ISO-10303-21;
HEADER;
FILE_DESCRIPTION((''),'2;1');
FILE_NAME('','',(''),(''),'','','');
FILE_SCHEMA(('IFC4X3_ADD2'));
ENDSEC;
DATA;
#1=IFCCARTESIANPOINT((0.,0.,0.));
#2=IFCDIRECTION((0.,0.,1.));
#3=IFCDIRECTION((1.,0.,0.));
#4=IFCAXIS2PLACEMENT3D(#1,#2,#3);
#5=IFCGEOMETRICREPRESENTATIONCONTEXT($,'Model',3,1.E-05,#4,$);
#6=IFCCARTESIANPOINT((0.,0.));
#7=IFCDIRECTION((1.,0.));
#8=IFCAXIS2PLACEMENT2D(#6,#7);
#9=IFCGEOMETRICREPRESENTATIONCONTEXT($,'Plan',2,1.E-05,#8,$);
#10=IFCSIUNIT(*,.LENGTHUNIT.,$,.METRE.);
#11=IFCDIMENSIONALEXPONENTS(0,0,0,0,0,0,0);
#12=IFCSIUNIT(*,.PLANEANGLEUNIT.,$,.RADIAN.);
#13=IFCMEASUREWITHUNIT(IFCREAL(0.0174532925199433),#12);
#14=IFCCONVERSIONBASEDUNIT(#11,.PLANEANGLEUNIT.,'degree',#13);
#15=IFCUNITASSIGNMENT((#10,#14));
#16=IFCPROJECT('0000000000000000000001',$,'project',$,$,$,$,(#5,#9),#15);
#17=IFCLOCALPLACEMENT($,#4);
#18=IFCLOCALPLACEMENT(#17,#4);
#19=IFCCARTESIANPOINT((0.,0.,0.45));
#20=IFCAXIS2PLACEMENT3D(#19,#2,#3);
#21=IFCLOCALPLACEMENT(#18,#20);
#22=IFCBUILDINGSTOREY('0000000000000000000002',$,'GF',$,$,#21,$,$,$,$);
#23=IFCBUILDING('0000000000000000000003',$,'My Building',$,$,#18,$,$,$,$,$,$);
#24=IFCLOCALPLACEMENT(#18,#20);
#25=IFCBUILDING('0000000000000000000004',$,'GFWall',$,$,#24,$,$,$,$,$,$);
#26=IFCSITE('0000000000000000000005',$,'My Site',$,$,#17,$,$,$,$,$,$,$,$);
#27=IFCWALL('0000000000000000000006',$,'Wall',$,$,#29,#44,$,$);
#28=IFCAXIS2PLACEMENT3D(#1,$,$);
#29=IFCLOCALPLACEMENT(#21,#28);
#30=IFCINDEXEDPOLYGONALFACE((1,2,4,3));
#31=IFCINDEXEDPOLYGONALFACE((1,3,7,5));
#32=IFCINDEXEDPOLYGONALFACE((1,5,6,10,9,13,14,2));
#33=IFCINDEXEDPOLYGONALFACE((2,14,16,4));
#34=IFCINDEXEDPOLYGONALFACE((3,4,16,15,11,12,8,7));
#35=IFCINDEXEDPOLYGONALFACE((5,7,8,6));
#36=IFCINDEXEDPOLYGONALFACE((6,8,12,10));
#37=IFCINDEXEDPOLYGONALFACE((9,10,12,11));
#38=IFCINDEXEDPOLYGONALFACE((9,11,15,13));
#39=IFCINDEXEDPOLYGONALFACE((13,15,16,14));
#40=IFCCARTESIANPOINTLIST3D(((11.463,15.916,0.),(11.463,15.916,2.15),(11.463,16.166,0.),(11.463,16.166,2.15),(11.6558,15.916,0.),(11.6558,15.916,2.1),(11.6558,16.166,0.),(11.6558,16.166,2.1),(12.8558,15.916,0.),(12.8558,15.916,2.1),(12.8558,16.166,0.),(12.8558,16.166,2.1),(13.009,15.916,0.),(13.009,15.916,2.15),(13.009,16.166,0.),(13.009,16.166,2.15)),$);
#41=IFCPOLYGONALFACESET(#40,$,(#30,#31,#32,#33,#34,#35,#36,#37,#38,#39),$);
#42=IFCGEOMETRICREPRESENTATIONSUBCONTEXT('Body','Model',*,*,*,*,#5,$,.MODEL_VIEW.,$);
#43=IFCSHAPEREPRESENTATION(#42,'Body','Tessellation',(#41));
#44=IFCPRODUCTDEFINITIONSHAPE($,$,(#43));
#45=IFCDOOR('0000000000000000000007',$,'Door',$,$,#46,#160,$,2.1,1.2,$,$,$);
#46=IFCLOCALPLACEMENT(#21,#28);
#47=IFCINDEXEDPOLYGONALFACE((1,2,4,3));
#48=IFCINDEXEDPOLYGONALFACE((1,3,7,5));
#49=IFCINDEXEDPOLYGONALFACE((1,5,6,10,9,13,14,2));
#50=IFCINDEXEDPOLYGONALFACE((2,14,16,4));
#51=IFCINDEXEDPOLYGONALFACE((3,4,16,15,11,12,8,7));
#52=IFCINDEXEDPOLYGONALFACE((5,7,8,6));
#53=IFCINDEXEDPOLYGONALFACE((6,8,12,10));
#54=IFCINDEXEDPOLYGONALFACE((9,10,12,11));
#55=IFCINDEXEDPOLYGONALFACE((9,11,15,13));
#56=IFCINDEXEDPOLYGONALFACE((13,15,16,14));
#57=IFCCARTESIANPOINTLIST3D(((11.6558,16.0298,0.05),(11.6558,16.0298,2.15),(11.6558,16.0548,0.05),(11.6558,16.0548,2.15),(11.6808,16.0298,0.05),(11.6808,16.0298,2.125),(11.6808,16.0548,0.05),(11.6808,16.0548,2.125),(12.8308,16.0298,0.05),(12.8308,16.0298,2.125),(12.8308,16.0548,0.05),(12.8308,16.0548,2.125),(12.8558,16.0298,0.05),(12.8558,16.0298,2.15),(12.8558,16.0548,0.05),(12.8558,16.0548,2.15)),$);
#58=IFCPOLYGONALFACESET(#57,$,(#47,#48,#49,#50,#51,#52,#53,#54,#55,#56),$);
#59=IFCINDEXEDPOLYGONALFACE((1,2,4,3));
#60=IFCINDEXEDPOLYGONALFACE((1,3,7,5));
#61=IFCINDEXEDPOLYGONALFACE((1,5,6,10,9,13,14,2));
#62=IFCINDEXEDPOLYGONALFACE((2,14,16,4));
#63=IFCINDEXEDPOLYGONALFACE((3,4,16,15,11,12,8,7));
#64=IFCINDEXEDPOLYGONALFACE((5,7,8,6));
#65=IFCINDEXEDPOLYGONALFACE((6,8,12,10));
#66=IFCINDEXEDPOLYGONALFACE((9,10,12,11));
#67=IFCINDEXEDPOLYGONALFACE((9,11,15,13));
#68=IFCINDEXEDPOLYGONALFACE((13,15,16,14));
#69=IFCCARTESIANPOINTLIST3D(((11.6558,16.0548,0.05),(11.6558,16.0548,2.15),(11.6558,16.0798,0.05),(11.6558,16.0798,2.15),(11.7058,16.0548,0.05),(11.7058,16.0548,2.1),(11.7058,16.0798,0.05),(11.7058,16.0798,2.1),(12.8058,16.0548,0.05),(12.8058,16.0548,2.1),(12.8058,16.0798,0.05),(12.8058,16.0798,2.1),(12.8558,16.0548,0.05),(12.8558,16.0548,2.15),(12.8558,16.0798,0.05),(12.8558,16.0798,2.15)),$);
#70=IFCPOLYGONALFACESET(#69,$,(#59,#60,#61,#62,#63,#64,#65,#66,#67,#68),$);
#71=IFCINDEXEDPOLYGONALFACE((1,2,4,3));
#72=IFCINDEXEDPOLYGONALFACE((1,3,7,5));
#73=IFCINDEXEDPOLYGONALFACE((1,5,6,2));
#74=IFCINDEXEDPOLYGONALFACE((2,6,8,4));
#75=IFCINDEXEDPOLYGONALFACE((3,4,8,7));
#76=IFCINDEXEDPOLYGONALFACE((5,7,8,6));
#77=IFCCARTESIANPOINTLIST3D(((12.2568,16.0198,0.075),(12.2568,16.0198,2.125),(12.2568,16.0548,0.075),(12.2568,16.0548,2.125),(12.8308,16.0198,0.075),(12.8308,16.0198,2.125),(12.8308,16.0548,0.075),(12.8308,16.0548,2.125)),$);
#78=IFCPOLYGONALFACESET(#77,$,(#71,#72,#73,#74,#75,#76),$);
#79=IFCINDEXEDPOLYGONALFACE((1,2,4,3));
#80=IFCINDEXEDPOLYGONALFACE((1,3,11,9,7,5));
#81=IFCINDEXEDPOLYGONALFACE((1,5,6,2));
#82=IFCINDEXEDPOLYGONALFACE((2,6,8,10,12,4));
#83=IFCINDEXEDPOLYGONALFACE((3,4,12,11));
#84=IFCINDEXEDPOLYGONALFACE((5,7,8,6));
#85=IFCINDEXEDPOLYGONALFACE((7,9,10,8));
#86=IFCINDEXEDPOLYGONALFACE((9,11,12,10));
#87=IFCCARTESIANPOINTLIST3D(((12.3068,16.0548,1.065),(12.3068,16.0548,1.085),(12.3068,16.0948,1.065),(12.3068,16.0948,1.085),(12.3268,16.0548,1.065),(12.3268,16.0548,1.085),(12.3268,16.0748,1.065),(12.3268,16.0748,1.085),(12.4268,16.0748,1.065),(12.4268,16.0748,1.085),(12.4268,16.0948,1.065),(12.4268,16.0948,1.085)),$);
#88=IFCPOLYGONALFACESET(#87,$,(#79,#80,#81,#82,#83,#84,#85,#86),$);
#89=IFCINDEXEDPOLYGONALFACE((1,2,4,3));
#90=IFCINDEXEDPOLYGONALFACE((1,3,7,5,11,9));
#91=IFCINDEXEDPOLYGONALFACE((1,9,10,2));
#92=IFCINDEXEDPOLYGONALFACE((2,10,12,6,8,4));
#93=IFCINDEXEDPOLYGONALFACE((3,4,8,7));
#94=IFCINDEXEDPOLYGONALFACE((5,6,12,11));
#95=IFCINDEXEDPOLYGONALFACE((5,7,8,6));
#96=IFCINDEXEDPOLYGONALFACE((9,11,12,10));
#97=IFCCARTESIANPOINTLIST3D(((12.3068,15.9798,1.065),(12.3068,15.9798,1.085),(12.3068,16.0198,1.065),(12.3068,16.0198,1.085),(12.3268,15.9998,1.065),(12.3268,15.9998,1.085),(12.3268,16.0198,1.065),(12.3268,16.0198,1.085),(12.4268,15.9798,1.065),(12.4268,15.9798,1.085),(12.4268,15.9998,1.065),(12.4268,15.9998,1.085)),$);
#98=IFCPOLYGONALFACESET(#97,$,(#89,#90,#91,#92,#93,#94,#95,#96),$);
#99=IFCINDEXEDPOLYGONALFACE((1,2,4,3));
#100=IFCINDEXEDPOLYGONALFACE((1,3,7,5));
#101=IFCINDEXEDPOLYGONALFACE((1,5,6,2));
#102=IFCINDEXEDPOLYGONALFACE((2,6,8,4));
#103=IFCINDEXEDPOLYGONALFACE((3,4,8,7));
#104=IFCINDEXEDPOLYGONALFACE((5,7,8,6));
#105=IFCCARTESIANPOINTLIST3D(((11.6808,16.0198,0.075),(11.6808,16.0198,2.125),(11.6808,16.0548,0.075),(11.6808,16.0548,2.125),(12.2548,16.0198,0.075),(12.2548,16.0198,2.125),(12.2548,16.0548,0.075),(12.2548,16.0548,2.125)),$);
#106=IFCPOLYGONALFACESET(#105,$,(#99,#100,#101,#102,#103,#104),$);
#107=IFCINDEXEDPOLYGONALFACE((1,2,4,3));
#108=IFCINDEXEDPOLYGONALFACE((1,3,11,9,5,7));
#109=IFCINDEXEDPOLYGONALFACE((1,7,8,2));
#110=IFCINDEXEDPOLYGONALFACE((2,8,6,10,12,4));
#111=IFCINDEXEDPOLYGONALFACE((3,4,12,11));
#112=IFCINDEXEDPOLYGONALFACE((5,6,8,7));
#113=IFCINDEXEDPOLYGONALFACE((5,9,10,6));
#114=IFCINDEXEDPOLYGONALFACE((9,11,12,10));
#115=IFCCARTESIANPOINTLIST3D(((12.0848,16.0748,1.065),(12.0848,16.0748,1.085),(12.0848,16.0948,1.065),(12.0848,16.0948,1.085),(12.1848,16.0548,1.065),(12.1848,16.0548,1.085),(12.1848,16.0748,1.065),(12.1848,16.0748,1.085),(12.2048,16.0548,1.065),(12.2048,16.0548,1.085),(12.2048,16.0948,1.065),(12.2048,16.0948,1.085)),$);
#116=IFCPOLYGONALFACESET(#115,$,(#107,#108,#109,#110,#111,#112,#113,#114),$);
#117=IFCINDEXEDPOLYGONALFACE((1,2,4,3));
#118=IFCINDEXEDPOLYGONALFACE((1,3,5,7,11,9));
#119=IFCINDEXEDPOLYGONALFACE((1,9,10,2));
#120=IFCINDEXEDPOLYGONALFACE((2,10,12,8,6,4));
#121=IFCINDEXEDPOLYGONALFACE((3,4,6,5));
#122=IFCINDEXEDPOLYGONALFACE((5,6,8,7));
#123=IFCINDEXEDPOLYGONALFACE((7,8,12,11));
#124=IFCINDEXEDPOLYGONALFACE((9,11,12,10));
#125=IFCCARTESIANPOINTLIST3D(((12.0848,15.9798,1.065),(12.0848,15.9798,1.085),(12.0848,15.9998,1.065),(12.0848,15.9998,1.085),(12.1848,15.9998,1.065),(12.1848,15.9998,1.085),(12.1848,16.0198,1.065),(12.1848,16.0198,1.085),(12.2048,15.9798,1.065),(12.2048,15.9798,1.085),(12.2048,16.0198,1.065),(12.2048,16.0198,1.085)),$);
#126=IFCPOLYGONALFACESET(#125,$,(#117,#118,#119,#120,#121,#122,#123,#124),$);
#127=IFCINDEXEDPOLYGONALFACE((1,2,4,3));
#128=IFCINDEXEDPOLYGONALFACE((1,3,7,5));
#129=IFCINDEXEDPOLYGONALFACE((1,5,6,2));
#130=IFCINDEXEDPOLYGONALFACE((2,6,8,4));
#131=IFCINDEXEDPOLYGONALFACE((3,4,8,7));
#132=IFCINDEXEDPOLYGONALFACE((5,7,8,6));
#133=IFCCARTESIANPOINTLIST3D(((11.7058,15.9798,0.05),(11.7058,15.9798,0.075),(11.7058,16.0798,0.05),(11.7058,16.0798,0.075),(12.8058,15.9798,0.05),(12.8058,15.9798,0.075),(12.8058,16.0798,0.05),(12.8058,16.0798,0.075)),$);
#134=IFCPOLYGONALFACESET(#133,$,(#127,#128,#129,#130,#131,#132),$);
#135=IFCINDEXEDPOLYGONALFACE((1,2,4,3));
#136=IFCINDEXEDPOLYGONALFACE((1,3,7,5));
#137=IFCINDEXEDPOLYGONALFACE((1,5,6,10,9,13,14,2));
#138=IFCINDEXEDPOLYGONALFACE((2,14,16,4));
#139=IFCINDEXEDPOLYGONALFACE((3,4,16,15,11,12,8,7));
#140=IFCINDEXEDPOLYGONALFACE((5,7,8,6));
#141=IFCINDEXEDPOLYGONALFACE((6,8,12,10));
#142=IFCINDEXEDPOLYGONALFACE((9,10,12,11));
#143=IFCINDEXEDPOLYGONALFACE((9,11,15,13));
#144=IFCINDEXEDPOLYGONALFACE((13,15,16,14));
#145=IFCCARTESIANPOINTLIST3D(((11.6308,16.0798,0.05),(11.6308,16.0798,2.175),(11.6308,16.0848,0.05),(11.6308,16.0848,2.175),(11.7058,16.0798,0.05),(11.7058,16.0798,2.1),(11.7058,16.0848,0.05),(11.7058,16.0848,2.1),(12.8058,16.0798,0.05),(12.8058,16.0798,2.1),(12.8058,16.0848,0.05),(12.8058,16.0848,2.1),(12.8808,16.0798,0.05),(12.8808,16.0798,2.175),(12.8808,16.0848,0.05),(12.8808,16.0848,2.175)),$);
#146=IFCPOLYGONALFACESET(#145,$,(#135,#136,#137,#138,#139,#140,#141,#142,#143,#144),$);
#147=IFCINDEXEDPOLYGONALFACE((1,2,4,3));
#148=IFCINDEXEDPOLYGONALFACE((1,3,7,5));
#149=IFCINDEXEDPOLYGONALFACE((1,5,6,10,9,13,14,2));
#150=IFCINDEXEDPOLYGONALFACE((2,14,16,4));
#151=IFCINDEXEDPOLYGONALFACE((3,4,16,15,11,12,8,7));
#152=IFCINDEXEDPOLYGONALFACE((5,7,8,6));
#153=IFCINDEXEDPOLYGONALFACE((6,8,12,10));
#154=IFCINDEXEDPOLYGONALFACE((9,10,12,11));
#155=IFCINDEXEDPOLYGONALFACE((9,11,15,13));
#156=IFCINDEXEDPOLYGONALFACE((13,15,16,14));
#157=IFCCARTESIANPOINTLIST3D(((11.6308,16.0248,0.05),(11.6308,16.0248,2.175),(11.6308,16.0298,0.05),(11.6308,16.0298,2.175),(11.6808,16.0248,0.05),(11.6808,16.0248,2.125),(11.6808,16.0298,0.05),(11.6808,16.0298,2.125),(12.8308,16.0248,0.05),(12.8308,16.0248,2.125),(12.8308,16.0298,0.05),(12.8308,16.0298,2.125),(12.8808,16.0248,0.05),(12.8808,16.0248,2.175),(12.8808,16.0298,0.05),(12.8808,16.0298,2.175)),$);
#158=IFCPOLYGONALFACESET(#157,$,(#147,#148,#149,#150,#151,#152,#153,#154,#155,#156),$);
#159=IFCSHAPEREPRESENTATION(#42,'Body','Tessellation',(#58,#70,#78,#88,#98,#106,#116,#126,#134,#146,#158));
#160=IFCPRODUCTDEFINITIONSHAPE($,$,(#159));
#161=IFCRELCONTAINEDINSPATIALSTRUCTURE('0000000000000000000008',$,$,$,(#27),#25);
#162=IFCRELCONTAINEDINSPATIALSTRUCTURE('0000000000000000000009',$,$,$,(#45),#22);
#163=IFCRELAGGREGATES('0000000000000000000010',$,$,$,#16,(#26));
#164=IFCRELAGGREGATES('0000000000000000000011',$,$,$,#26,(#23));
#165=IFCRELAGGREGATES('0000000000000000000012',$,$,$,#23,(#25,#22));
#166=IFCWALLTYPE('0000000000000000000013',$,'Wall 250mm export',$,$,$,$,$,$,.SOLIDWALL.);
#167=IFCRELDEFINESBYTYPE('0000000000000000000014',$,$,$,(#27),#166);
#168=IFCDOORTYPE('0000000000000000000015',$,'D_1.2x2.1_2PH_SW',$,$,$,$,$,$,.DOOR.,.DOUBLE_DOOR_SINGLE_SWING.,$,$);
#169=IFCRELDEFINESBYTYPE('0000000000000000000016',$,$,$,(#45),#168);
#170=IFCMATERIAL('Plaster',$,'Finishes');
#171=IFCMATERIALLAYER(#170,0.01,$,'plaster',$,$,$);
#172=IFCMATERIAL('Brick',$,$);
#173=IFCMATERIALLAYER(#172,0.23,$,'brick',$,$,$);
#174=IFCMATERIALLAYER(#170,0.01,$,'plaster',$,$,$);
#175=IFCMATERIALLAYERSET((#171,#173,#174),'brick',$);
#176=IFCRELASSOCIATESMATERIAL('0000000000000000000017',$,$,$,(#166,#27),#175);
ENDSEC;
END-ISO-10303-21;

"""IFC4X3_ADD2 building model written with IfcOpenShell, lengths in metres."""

from ifc_helpers import new_model, entity, si_unit, converted_unit, frame, origin_with_axes, origin_2d_with_axis, place, context, subcontext, project, spatial, line, indexed_curve, outline, extrude, shape, source, transform, mapped, material, layer, layer_set, layer_usage, type_object, type_shapes, element, fill, save


model = new_model("IFC4X3_ADD2")

# Units and contexts
model_context = context("Model", 3, precision=1e-05, world=origin_with_axes())
plan_context = context("Plan", 2, precision=1e-05, world=origin_2d_with_axis())
body_context_1 = subcontext(model_context, "Body", "Model", "MODEL_VIEW")
body_context_2 = subcontext(plan_context, "Body", "Plan", "PLAN_VIEW")
ifc_project = project(units=[si_unit("LENGTHUNIT", "METRE"), converted_unit("PLANEANGLEUNIT", "degree", entity("IfcReal", 0.0174532925199433), si_unit("PLANEANGLEUNIT", "RADIAN"), dimensions=[0, 0, 0, 0, 0, 0, 0])], contexts=[model_context, plan_context])

# Site, buildings
site_placement = place(None, origin_with_axes())
site = spatial("IfcSite", under=ifc_project, at=site_placement, Name="My Site")
building_1_placement = place(site_placement, origin_with_axes())
building_1 = spatial("IfcBuilding", under=site, at=building_1_placement, Name="My Building")
building_2_placement = place(building_1_placement, frame((0.0, 0.0, 0.45), z_axis=(0.0, 0.0, 1.0), x_axis=(1.0, 0.0, 0.0)))
building_2 = spatial("IfcBuilding", under=building_1, at=building_2_placement, Name="GFWall")

# Shared definitions
ifc_material_1 = material(Name="Plaster", Category="Finishes")
ifc_layer_1 = layer(ifc_material_1, 0.01, Name="plaster")
ifc_material_2 = material(Name="Brick")
ifc_layer_2 = layer(ifc_material_2, 0.23, Name="brick")
ifc_layer_3 = layer(ifc_material_1, 0.01, Name="plaster")
ifc_layer_set = layer_set([ifc_layer_1, ifc_layer_2, ifc_layer_3], Name="brick")
wall_type = type_object("IfcWallType", Name="Wall 250mm export", PredefinedType="SOLIDWALL", material=ifc_layer_set)

# Shared definitions
storey_placement = place(building_1_placement, frame((0.0, 0.0, 0.45), z_axis=(0.0, 0.0, 1.0), x_axis=(1.0, 0.0, 0.0)))
storey = spatial("IfcBuildingStorey", under=building_1, at=storey_placement, Name="GF")

# Shared definitions
shared_shape_1 = source(origin_with_axes(), body_context_1, "Body", "SweptSolid", [
    extrude(outline(indexed_curve([(0.0, 0.0), (1.2, 0.0), (1.2, 2.1), (0.0, 2.1)], segments=[line(1, 2, 3, 4, 1)])), frame((0.0, -0.6, 0.0), z_axis=(0.0, -1.0, 0.0), x_axis=(1.0, 0.0, 0.0)), (0.0, 0.0, -1.0), 1.2),
])
door_type_1 = type_object("IfcDoorType", Name="D_1.2x2.1_2PH_SW", OperationType="DOUBLE_DOOR_SINGLE_SWING", PredefinedType="DOOR")
shared_shape_2 = source(origin_with_axes(), body_context_1, "Body", "SweptSolid", [
    extrude(outline(indexed_curve([(0.0, 0.0), (0.0, 2.1), (1.2, 2.1), (1.2, 0.0), (1.175, 0.0), (1.175, 2.075), (0.025, 2.075), (0.025, 0.0)], segments=[line(1, 2, 3, 4, 5, 6, 7, 8, 1)])), frame((0.0, 0.025, 0.0), z_axis=(0.0, -1.0, 0.0), x_axis=(1.0, 0.0, 0.0)), (0.0, 0.0, -1.0), 0.025),
    extrude(outline(indexed_curve([(0.0, 0.0), (0.0, 2.1), (1.2, 2.1), (1.2, 0.0), (1.15, 0.0), (1.15, 2.05), (0.05, 2.05), (0.05, 0.0)], segments=[line(1, 2, 3, 4, 5, 6, 7, 8, 1)])), frame((0.0, 0.0, 0.0), z_axis=(0.0, -1.0, 0.0), x_axis=(1.0, 0.0, 0.0)), (0.0, 0.0, -1.0), 0.025),
    extrude(outline(indexed_curve([(0.0, 0.0), (0.574, 0.0), (0.574, 0.035), (0.0, 0.035)], segments=[line(1, 2, 3, 4, 1)])), frame((0.025, 0.025, 0.025), z_axis=(0.0, 0.0, 1.0), x_axis=(1.0, 0.0, 0.0)), (0.0, 0.0, 1.0), 2.05),
    extrude(outline(indexed_curve([(0.0, 0.0), (0.0, -0.04), (-0.12, -0.04), (-0.12, -0.02), (-0.02, -0.02), (-0.02, 0.0)], segments=[line(1, 2, 3, 4, 5, 6, 1)])), frame((0.549, 0.025, 1.015), z_axis=(0.0, 0.0, 1.0), x_axis=(1.0, 0.0, 0.0)), (0.0, 0.0, 1.0), 0.02),
    extrude(outline(indexed_curve([(0.0, 0.0), (0.0, 0.04), (-0.12, 0.04), (-0.12, 0.02), (-0.02, 0.02), (-0.02, 0.0)], segments=[line(1, 2, 3, 4, 5, 6, 1)])), frame((0.549, 0.06, 1.015), z_axis=(0.0, 0.0, 1.0), x_axis=(1.0, 0.0, 0.0)), (0.0, 0.0, 1.0), 0.02),
    extrude(outline(indexed_curve([(0.0, 0.0), (-0.574, 0.0), (-0.574, 0.035), (0.0, 0.035)], segments=[line(1, 2, 3, 4, 1)])), frame((1.175, 0.025, 0.025), z_axis=(0.0, 0.0, 1.0), x_axis=(1.0, 0.0, 0.0)), (0.0, 0.0, 1.0), 2.05),
    extrude(outline(indexed_curve([(0.0, 0.0), (0.0, -0.04), (0.12, -0.04), (0.12, -0.02), (0.02, -0.02), (0.02, 0.0)], segments=[line(1, 2, 3, 4, 5, 6, 1)])), frame((0.651, 0.025, 1.015), z_axis=(0.0, 0.0, 1.0), x_axis=(1.0, 0.0, 0.0)), (0.0, 0.0, 1.0), 0.02),
    extrude(outline(indexed_curve([(0.0, 0.0), (0.0, 0.04), (0.12, 0.04), (0.12, 0.02), (0.02, 0.02), (0.02, 0.0)], segments=[line(1, 2, 3, 4, 5, 6, 1)])), frame((0.651, 0.06, 1.015), z_axis=(0.0, 0.0, 1.0), x_axis=(1.0, 0.0, 0.0)), (0.0, 0.0, 1.0), 0.02),
    extrude(outline(indexed_curve([(0.0, 0.0), (1.1, 0.0), (1.1, 0.1), (0.0, 0.1)], segments=[line(1, 2, 3, 4, 1)])), frame((0.05, 0.0, 0.0), z_axis=(0.0, 0.0, 1.0), x_axis=(1.0, 0.0, 0.0)), (0.0, 0.0, 1.0), 0.025),
    extrude(outline(indexed_curve([(0.0, 0.0), (0.0, 2.125), (1.25, 2.125), (1.25, 0.0), (1.175, 0.0), (1.175, 2.05), (0.075, 2.05), (0.075, 0.0)], segments=[line(1, 2, 3, 4, 5, 6, 7, 8, 1)])), frame((-0.025, -0.005, 0.0), z_axis=(0.0, -1.0, 0.0), x_axis=(1.0, 0.0, 0.0)), (0.0, 0.0, -1.0), 0.005),
    extrude(outline(indexed_curve([(0.0, 0.0), (0.0, 2.125), (1.25, 2.125), (1.25, 0.0), (1.2, 0.0), (1.2, 2.075), (0.05, 2.075), (0.05, 0.0)], segments=[line(1, 2, 3, 4, 5, 6, 7, 8, 1)])), frame((-0.025, 0.05, 0.0), z_axis=(0.0, -1.0, 0.0), x_axis=(1.0, 0.0, 0.0)), (0.0, 0.0, -1.0), 0.005),
])
shared_shape_3 = source(origin_with_axes(), body_context_2, "Body", "Curve2D", [
    entity("IfcIndexedPolyCurve", entity("IfcCartesianPointList2D", [[0.0, 0.0], [0.0, 0.05], [0.025, 0.05], [0.025, 0.025], [0.05, 0.025], [0.05, 0.0]]), [entity("IfcLineIndex", [1, 2, 3, 4, 5, 6, 1])]),
    entity("IfcIndexedPolyCurve", entity("IfcCartesianPointList2D", [[1.2, 0.0], [1.2, 0.05], [1.175, 0.05], [1.175, 0.025], [1.15, 0.025], [1.15, 0.0]]), [entity("IfcLineIndex", [1, 2, 3, 4, 5, 6, 1])]),
    entity("IfcTrimmedCurve", entity("IfcEllipse", entity("IfcAxis2Placement2D", entity("IfcCartesianPoint", [0.06, 0.05]), entity("IfcDirection", [1.0, 0.0])), 0.54, 0.575), [entity("IfcCartesianPoint", [0.6, 0.05])], [entity("IfcCartesianPoint", [0.06, 0.625])], True, "CARTESIAN"),
    entity("IfcIndexedPolyCurve", entity("IfcCartesianPointList2D", [[0.025, 0.05], [0.06, 0.05], [0.06, 0.625], [0.025, 0.625]]), [entity("IfcLineIndex", [1, 2, 3, 4, 1])]),
    entity("IfcTrimmedCurve", entity("IfcEllipse", entity("IfcAxis2Placement2D", entity("IfcCartesianPoint", [1.14, 0.05]), entity("IfcDirection", [1.0, 0.0])), 0.54, 0.575), [entity("IfcCartesianPoint", [1.14, 0.625])], [entity("IfcCartesianPoint", [0.6, 0.05])], True, "CARTESIAN"),
    entity("IfcIndexedPolyCurve", entity("IfcCartesianPointList2D", [[1.175, 0.05], [1.14, 0.05], [1.14, 0.625], [1.175, 0.625]]), [entity("IfcLineIndex", [1, 2, 3, 4, 1])]),
])
type_shapes(door_type_1, [shared_shape_2, shared_shape_3])

# Wall, opening, door
ifc_layer_usage_1 = layer_usage(ifc_layer_set, "AXIS2", "POSITIVE", 0.0)
wall_1_placement = place(building_2_placement, frame((11.463, 15.916, 0.0), z_axis=(0.0, 0.0, 1.0), x_axis=(1.0, 0.0, 0.0)))
wall_1 = element("IfcWall", 1, at=wall_1_placement, inside=building_2, type_object=wall_type, material=ifc_layer_usage_1, Name="Wall", context=body_context_1, shape_type="SweptSolid", body=[
    extrude(outline(indexed_curve([(0.0, 0.0), (0.0, 0.25), (1.546, 0.25), (1.546, 0.0)], segments=[line(1, 2, 3, 4, 1)])), origin_with_axes(), (0.0, 0.0, 1.0), 2.15),
])
opening_1_placement = place(wall_1_placement, frame((1.3928, 0.1638, 0.0), z_axis=(0.0, 0.0, 1.0), x_axis=(-1.0, 0.0, 0.0)))
opening_1 = element("IfcOpeningElement", 2, at=opening_1_placement, cuts=wall_1, PredefinedType="OPENING", context=body_context_1, shape_type="MappedRepresentation", body=[
    mapped(shared_shape_1, transform((0.0, 0.0, 0.0), x_axis=(1.0, 0.0, 0.0), y_axis=(0.0, 1.0, 0.0), z_axis=(0.0, 0.0, 1.0), scale=1.0)),
])
door_1_placement = place(opening_1_placement, frame((0.0, 0.0, 0.05), z_axis=(0.0, 0.0, 1.0), x_axis=(1.0, 0.0, 0.0)))
door_1 = element("IfcDoor", 3, at=door_1_placement, inside=storey, type_object=door_type_1, Name="Door", OverallHeight=2.1, OverallWidth=1.2, shapes=[
    shape(body_context_1, "Body", "MappedRepresentation", [mapped(shared_shape_2, transform((0.0, 0.0, 0.0), x_axis=(1.0, 0.0, 0.0), y_axis=(0.0, 1.0, 0.0), z_axis=(0.0, 0.0, 1.0), scale=1.0))]),
    shape(body_context_2, "Body", "MappedRepresentation", [mapped(shared_shape_3, transform((0.0, 0.0, 0.0), x_axis=(1.0, 0.0, 0.0), y_axis=(0.0, 1.0, 0.0), z_axis=(0.0, 0.0, 1.0), scale=1.0))]),
])
fill(opening_1, door_1)

save(model, "model.ifc")
